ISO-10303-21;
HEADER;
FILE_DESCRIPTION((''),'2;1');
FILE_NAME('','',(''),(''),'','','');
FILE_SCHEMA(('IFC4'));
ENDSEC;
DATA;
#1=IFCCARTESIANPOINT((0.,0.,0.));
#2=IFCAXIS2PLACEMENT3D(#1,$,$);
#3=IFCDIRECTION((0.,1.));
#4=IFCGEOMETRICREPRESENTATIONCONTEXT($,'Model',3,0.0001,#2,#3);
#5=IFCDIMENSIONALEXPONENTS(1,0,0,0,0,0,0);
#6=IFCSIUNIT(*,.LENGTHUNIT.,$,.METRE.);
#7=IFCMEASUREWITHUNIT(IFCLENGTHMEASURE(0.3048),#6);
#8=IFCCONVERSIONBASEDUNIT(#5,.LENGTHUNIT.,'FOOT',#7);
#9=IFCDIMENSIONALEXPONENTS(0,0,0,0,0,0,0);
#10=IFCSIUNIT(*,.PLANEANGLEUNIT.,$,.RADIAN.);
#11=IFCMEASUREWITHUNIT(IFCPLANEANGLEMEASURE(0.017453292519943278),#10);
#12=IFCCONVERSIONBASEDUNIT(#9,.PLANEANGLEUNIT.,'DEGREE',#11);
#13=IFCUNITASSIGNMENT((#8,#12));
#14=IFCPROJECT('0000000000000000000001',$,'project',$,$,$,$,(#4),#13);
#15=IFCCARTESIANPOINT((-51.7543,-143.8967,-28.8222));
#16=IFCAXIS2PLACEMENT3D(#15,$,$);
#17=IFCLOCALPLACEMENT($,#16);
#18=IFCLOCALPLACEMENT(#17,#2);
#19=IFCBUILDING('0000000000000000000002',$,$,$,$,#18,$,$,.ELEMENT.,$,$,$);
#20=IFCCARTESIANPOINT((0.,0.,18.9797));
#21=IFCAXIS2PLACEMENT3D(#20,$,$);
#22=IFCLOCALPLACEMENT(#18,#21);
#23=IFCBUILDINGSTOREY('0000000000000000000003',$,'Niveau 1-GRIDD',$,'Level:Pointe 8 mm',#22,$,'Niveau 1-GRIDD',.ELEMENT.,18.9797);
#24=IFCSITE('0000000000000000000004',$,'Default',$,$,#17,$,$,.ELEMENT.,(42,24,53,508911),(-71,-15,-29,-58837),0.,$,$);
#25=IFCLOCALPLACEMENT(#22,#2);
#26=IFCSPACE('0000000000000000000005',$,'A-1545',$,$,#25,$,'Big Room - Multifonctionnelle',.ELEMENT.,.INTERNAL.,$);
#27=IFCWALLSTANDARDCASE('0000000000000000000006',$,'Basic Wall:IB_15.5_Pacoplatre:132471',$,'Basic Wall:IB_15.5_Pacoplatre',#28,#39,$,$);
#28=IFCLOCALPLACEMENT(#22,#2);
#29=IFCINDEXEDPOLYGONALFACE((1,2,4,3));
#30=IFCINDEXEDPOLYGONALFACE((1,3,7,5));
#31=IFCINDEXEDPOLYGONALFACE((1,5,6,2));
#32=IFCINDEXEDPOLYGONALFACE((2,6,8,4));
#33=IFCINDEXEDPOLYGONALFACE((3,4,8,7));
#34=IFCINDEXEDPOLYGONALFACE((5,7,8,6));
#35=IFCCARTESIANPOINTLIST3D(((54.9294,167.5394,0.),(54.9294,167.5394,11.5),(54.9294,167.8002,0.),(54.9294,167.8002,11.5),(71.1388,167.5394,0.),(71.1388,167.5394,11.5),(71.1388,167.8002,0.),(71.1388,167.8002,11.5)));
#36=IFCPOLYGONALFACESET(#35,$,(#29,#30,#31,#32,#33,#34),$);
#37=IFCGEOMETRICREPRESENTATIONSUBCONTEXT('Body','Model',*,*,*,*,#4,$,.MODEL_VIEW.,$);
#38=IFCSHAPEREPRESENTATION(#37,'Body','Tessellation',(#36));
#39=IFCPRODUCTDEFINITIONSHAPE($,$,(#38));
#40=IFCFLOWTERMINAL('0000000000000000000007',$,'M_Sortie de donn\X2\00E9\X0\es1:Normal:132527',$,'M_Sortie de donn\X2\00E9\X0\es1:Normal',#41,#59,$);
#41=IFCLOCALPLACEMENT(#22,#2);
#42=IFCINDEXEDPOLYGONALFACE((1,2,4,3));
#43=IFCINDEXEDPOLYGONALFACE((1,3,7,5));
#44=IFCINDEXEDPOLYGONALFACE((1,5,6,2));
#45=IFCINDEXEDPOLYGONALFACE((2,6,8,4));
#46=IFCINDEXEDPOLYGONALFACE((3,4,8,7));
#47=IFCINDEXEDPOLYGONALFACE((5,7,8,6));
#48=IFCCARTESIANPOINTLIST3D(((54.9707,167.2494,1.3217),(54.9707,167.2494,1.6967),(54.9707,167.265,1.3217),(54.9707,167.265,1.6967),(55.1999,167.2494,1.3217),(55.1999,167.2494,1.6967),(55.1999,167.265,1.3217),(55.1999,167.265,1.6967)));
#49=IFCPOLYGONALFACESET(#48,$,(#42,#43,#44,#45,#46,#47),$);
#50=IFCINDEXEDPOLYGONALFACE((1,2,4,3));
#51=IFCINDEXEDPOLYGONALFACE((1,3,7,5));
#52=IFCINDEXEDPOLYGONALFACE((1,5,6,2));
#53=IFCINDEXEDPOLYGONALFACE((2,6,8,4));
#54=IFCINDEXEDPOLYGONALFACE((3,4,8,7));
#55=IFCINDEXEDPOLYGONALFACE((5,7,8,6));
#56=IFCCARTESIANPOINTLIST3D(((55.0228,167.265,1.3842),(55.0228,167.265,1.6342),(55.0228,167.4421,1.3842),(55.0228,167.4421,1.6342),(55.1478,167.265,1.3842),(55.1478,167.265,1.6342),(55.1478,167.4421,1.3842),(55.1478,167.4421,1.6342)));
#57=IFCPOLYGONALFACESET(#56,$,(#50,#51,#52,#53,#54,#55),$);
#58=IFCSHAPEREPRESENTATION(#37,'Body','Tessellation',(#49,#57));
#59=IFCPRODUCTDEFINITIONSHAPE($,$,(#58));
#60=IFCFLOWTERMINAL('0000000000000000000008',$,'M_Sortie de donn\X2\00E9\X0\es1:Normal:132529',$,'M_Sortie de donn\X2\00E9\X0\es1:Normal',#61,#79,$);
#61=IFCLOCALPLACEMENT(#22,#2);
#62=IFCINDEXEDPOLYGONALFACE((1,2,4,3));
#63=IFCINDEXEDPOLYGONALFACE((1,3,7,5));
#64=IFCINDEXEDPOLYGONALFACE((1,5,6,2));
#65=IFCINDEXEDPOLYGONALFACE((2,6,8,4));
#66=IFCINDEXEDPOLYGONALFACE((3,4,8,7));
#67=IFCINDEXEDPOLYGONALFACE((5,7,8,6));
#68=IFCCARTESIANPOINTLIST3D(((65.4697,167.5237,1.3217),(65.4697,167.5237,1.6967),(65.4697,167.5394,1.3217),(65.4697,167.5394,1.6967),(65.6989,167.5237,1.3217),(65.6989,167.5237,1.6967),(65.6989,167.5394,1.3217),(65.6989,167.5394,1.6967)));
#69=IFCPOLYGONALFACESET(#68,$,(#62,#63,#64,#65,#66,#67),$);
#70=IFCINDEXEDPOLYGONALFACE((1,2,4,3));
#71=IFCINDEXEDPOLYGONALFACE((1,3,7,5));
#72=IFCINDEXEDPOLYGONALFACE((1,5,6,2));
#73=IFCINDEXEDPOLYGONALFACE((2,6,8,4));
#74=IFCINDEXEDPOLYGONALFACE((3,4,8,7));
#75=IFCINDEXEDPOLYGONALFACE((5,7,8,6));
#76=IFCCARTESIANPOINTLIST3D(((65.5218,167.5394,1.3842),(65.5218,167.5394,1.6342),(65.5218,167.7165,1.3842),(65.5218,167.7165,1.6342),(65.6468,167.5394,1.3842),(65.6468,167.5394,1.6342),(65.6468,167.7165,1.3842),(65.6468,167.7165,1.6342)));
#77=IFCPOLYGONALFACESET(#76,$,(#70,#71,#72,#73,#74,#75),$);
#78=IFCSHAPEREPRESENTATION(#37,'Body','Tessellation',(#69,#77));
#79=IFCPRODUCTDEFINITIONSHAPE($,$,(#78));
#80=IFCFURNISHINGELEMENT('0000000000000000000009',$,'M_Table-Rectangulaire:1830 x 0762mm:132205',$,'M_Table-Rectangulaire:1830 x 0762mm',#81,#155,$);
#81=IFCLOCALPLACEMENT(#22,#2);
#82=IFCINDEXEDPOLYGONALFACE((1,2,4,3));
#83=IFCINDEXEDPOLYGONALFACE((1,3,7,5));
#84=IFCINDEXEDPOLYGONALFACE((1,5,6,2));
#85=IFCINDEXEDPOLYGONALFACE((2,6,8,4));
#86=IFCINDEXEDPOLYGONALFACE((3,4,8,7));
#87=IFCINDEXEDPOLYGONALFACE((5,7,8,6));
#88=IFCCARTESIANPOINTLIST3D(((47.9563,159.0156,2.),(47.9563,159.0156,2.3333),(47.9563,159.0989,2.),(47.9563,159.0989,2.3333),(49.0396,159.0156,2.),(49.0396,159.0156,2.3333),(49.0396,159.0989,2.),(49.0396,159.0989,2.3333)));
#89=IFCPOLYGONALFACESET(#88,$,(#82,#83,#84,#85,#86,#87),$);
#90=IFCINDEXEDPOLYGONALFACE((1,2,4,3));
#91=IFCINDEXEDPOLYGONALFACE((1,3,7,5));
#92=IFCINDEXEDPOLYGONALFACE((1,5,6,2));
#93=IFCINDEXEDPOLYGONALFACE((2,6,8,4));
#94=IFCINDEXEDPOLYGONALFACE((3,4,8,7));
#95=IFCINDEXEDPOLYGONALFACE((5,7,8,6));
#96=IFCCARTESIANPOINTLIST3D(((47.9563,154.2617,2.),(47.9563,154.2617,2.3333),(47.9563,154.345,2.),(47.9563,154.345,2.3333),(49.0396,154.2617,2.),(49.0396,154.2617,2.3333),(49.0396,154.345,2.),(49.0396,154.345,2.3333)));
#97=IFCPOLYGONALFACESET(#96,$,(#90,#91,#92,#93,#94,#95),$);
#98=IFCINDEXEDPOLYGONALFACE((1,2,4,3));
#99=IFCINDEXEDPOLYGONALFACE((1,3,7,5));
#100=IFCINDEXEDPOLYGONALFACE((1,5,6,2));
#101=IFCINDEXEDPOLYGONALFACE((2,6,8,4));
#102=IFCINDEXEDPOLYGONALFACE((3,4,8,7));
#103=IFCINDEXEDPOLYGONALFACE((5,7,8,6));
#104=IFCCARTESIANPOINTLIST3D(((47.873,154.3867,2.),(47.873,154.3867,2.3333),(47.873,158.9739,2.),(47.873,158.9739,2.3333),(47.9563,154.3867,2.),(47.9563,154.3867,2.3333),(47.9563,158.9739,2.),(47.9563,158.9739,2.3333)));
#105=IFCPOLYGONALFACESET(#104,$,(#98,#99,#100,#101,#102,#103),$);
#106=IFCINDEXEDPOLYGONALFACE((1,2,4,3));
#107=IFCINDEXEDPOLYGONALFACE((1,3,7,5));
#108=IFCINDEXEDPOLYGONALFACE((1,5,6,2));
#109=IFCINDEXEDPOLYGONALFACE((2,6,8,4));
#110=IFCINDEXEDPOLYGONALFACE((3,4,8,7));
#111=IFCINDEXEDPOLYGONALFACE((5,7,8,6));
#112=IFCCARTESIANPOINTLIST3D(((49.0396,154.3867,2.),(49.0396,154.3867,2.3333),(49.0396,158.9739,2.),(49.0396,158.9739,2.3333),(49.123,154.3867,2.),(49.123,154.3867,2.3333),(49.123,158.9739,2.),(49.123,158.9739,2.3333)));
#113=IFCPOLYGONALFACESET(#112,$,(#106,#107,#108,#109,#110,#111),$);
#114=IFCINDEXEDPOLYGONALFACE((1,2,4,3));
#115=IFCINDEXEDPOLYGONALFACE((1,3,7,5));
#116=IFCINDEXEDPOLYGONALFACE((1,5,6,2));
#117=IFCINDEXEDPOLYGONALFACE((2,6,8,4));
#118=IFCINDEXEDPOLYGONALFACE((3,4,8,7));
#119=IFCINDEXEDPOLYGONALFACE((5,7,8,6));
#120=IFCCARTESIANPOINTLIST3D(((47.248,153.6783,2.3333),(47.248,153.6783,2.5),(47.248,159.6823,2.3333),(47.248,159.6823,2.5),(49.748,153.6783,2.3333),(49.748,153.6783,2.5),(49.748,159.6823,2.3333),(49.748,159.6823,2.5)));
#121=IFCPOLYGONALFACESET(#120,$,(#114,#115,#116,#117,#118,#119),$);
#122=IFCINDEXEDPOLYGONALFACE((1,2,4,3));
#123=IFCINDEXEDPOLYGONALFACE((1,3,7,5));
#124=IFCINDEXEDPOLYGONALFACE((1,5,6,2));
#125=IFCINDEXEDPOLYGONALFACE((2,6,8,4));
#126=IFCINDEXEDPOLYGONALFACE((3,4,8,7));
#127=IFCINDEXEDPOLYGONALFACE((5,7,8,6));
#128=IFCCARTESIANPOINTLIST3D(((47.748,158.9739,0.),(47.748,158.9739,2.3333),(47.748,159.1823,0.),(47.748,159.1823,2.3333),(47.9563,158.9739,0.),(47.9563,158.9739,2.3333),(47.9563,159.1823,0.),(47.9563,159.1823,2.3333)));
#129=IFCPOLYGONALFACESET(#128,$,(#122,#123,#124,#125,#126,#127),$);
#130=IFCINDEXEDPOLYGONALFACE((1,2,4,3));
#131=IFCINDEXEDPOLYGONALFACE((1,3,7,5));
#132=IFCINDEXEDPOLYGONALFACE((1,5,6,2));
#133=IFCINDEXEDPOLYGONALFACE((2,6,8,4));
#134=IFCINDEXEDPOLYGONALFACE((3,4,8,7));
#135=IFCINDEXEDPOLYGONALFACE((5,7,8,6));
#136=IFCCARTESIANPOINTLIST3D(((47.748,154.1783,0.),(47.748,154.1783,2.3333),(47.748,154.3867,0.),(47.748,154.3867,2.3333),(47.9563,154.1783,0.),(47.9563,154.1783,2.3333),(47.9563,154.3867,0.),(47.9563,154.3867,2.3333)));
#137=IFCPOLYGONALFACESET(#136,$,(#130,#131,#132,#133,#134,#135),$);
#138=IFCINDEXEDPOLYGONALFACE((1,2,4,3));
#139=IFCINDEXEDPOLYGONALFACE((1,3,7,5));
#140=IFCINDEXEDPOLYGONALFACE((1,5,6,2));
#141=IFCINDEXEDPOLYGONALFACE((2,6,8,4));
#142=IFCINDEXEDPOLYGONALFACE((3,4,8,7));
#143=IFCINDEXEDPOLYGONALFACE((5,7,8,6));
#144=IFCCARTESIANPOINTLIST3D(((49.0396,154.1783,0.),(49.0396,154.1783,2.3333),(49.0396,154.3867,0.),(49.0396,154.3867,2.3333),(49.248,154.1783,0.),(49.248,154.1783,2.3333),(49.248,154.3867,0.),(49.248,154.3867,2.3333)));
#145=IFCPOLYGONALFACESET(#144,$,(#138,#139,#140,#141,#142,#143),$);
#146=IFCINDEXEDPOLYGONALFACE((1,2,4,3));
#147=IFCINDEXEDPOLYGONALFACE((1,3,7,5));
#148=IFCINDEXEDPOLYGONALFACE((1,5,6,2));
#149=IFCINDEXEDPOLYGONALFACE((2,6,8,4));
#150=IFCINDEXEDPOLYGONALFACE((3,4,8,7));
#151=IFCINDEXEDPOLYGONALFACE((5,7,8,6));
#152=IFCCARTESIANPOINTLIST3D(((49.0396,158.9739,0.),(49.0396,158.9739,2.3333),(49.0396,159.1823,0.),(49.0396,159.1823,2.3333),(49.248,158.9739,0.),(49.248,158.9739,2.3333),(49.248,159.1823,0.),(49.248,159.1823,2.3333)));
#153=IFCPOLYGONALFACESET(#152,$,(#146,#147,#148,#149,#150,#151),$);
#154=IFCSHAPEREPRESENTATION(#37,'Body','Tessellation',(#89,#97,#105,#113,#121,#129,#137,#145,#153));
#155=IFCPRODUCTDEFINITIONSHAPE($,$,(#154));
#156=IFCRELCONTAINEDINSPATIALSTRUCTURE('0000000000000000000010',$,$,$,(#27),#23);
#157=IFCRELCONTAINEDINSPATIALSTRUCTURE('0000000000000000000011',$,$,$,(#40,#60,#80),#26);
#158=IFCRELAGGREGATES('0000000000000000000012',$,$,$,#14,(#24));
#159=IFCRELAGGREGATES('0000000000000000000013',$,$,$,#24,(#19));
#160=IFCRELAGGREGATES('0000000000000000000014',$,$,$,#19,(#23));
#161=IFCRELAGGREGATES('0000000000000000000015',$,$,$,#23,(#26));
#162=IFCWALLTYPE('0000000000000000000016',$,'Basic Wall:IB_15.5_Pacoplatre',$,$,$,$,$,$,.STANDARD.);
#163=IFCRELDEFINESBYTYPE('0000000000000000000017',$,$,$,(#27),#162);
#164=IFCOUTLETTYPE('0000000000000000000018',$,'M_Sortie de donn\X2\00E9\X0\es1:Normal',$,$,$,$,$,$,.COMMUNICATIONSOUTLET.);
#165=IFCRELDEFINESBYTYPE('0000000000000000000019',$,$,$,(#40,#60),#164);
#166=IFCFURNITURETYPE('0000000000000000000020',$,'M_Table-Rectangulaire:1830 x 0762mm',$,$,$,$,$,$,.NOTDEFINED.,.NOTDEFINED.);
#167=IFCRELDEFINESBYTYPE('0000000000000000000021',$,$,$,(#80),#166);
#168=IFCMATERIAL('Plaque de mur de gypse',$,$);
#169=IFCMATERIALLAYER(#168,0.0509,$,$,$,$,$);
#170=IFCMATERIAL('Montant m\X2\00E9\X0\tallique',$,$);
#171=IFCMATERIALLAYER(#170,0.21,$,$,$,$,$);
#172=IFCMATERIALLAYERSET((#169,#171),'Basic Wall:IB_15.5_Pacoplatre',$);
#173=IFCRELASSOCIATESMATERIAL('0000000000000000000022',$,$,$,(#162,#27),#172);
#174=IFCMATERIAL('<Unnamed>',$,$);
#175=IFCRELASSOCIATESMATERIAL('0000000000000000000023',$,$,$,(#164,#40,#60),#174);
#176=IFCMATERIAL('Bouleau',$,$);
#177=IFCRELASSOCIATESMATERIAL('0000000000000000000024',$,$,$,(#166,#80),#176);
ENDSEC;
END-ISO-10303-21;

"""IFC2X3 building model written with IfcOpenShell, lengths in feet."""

from ifc_helpers import new_model, entity, si_unit, converted_unit, direction, frame, frame_2d, origin, origin_2d_with_axis, place, context, subcontext, project, spatial, rectangle, extrude, source, transform, mapped, material, layer, layer_set, layer_usage, type_object, type_shapes, element, save


model = new_model("IFC2X3")

# Units and contexts
model_context = context("Model", 3, precision=0.0001, world=origin(), true_north=direction((0.0, 1.0)))
body_context = subcontext(model_context, "Body", "Model", "MODEL_VIEW")
ifc_project = project(units=[converted_unit("LENGTHUNIT", "FOOT", entity("IfcLengthMeasure", 0.3048), si_unit("LENGTHUNIT", "METRE"), dimensions=[1, 0, 0, 0, 0, 0, 0]), converted_unit("PLANEANGLEUNIT", "DEGREE", entity("IfcPlaneAngleMeasure", 0.017453292519943278), si_unit("PLANEANGLEUNIT", "RADIAN"), dimensions=[0, 0, 0, 0, 0, 0, 0])], contexts=[model_context])

# Site, building, storey
site_placement = place(None, frame((-51.7543, -143.8967, -28.8222)))
site = spatial("IfcSite", under=ifc_project, at=site_placement, Name="Default", CompositionType="ELEMENT", RefLatitude=(42, 24, 53, 508911), RefLongitude=(-71, -15, -29, -58837), RefElevation=0.0)
building_placement = place(site_placement, origin())
building = spatial("IfcBuilding", under=site, at=building_placement, CompositionType="ELEMENT")
storey_placement = place(building_placement, frame((0.0, 0.0, 18.9797)))
storey = spatial("IfcBuildingStorey", under=building, at=storey_placement, Name="Niveau 1-GRIDD", ObjectType="Level:Pointe 8 mm", LongName="Niveau 1-GRIDD", CompositionType="ELEMENT", Elevation=18.9797)

# Shared definitions
ifc_material_1 = material(Name="Plaque de mur de gypse")
ifc_material_2 = material(Name="Montant métallique")

# Wall
ifc_layer_1 = layer(ifc_material_1, 0.0509)
ifc_layer_2 = layer(ifc_material_2, 0.21)
ifc_layer_set_1 = layer_set([ifc_layer_1, ifc_layer_2], Name="Basic Wall:IB_15.5_Pacoplatre")
wall_type_1 = type_object("IfcWallType", Name="Basic Wall:IB_15.5_Pacoplatre", PredefinedType="STANDARD", material=ifc_layer_set_1)
ifc_layer_usage_1 = layer_usage(ifc_layer_set_1, "AXIS2", "NEGATIVE", 0.1304)
wall_1_placement = place(storey_placement, frame((54.9294, 167.6698, 0.0)))
element("IfcWallStandardCase", 1, at=wall_1_placement, inside=storey, type_object=wall_type_1, material=ifc_layer_usage_1, Name="Basic Wall:IB_15.5_Pacoplatre:132471", ObjectType="Basic Wall:IB_15.5_Pacoplatre", context=body_context, shape_type="SweptSolid", body=[
    extrude(rectangle(XDim=16.2094, YDim=0.2608, at=frame_2d((8.1047, 0.0), x_axis=(-1.0, 0.0))), origin(), (0.0, 0.0, 1.0), 11.5),
])

# Shared definitions
space_placement = place(storey_placement, origin())
space = spatial("IfcSpace", under=storey, at=space_placement, Name="A-1545", LongName="Big Room - Multifonctionnelle", CompositionType="ELEMENT", InteriorOrExteriorSpace="INTERNAL")

# Flow terminals
ifc_material_3 = material(Name="<Unnamed>")
outlet_type = type_object("IfcOutletType", Name="M_Sortie de données1:Normal", PredefinedType="COMMUNICATIONSOUTLET", material=ifc_material_3)
shared_shape_1 = source(origin(), body_context, "Body", "SweptSolid", [
    extrude(rectangle(XDim=0.2292, YDim=0.375, at=frame_2d((0.0, 0.0), x_axis=(1.0, 0.0))), frame((0.0, 0.0, 0.0), z_axis=(0.0, 0.0, 1.0), x_axis=(-1.0, 0.0, 0.0)), (0.0, 0.0, 1.0), 0.0156),
    extrude(rectangle(XDim=0.125, YDim=0.25, at=frame_2d((0.0, 0.0), x_axis=(1.0, 0.0))), frame((0.0, 0.0, -0.1771), z_axis=(0.0, 0.0, 1.0), x_axis=(-1.0, 0.0, 0.0)), (0.0, 0.0, 1.0), 0.1771),
])
type_shapes(outlet_type, [shared_shape_1])
for number, where, z_axis, x_axis, name in (
    (2, (55.0853, 167.265, 1.5092), (0.0, -1.0, 0.0), (1.0, 0.0, 0.0), "M_Sortie de données1:Normal:132527"),
    (3, (65.5843, 167.5394, 1.5092), (0.0, -1.0, 0.0), (1.0, 0.0, 0.0), "M_Sortie de données1:Normal:132529"),
):
    element("IfcFlowTerminal", number, at=place(space_placement, frame(where, z_axis=z_axis, x_axis=x_axis)), inside=space, type_object=outlet_type, material=ifc_material_3, Name=name, ObjectType="M_Sortie de données1:Normal", context=body_context, shape_type="MappedRepresentation", body=[
        mapped(shared_shape_1, transform((0.0, 0.0, 0.0), scale=1.0)),
    ])

# Furnishing element
ifc_material_4 = material(Name="Bouleau")
furniture_type_1 = type_object("IfcFurnitureType", Name="M_Table-Rectangulaire:1830 x 0762mm", AssemblyPlace="NOTDEFINED", material=ifc_material_4)
shared_shape_2 = source(origin(), body_context, "Body", "SweptSolid", [
    extrude(rectangle(XDim=0.0833, YDim=1.0833, at=origin_2d_with_axis()), frame((2.377, 0.0, 2.0)), (0.0, 0.0, 1.0), 0.3333),
    extrude(rectangle(XDim=1.0833, YDim=0.0833, at=origin_2d_with_axis()), frame((-2.377, 0.0, 2.0), z_axis=(0.0, 0.0, 1.0), x_axis=(0.0, 1.0, 0.0)), (0.0, 0.0, 1.0), 0.3333),
    extrude(rectangle(XDim=4.5873, YDim=0.0833, at=frame_2d((0.0, 0.0), x_axis=(1.0, 0.0))), frame((0.0, 0.5833, 2.0), z_axis=(0.0, 0.0, 1.0), x_axis=(-1.0, 0.0, 0.0)), (0.0, 0.0, 1.0), 0.3333),
    extrude(rectangle(XDim=0.0833, YDim=4.5873, at=origin_2d_with_axis()), frame((0.0, -0.5833, 2.0), z_axis=(0.0, 0.0, 1.0), x_axis=(0.0, 1.0, 0.0)), (0.0, 0.0, 1.0), 0.3333),
    extrude(rectangle(XDim=6.0039, YDim=2.5, at=origin_2d_with_axis()), frame((0.0, 0.0, 2.3333), z_axis=(0.0, 0.0, 1.0), x_axis=(-1.0, 0.0, 0.0)), (0.0, 0.0, 1.0), 0.1667),
    extrude(rectangle(XDim=0.2083, YDim=0.2083, at=origin_2d_with_axis()), frame((2.3978, 0.6458, 0.0), z_axis=(0.0, 0.0, 1.0), x_axis=(0.0, -1.0, 0.0)), (0.0, 0.0, 1.0), 2.3333),
    extrude(rectangle(XDim=0.2083, YDim=0.2083, at=origin_2d_with_axis()), frame((-2.3978, 0.6458, 0.0), z_axis=(0.0, 0.0, 1.0), x_axis=(-1.0, 0.0, 0.0)), (0.0, 0.0, 1.0), 2.3333),
    extrude(rectangle(XDim=0.2083, YDim=0.2083, at=origin_2d_with_axis()), frame((-2.3978, -0.6458, 0.0), z_axis=(0.0, 0.0, 1.0), x_axis=(0.0, 1.0, 0.0)), (0.0, 0.0, 1.0), 2.3333),
    extrude(rectangle(XDim=0.2083, YDim=0.2083, at=frame_2d((0.0, 0.0), x_axis=(1.0, 0.0))), frame((2.3978, -0.6458, 0.0)), (0.0, 0.0, 1.0), 2.3333),
])
type_shapes(furniture_type_1, [shared_shape_2])
furnishing_placement = place(space_placement, frame((48.498, 156.6803, 0.0), z_axis=(0.0, 0.0, 1.0), x_axis=(0.0, 1.0, 0.0)))
element("IfcFurnishingElement", 4, at=furnishing_placement, inside=space, type_object=furniture_type_1, material=ifc_material_4, Name="M_Table-Rectangulaire:1830 x 0762mm:132205", ObjectType="M_Table-Rectangulaire:1830 x 0762mm", context=body_context, shape_type="MappedRepresentation", body=[
    mapped(shared_shape_2, transform((0.0, 0.0, 0.0), scale=1.0)),
])

save(model, "model.ifc")
